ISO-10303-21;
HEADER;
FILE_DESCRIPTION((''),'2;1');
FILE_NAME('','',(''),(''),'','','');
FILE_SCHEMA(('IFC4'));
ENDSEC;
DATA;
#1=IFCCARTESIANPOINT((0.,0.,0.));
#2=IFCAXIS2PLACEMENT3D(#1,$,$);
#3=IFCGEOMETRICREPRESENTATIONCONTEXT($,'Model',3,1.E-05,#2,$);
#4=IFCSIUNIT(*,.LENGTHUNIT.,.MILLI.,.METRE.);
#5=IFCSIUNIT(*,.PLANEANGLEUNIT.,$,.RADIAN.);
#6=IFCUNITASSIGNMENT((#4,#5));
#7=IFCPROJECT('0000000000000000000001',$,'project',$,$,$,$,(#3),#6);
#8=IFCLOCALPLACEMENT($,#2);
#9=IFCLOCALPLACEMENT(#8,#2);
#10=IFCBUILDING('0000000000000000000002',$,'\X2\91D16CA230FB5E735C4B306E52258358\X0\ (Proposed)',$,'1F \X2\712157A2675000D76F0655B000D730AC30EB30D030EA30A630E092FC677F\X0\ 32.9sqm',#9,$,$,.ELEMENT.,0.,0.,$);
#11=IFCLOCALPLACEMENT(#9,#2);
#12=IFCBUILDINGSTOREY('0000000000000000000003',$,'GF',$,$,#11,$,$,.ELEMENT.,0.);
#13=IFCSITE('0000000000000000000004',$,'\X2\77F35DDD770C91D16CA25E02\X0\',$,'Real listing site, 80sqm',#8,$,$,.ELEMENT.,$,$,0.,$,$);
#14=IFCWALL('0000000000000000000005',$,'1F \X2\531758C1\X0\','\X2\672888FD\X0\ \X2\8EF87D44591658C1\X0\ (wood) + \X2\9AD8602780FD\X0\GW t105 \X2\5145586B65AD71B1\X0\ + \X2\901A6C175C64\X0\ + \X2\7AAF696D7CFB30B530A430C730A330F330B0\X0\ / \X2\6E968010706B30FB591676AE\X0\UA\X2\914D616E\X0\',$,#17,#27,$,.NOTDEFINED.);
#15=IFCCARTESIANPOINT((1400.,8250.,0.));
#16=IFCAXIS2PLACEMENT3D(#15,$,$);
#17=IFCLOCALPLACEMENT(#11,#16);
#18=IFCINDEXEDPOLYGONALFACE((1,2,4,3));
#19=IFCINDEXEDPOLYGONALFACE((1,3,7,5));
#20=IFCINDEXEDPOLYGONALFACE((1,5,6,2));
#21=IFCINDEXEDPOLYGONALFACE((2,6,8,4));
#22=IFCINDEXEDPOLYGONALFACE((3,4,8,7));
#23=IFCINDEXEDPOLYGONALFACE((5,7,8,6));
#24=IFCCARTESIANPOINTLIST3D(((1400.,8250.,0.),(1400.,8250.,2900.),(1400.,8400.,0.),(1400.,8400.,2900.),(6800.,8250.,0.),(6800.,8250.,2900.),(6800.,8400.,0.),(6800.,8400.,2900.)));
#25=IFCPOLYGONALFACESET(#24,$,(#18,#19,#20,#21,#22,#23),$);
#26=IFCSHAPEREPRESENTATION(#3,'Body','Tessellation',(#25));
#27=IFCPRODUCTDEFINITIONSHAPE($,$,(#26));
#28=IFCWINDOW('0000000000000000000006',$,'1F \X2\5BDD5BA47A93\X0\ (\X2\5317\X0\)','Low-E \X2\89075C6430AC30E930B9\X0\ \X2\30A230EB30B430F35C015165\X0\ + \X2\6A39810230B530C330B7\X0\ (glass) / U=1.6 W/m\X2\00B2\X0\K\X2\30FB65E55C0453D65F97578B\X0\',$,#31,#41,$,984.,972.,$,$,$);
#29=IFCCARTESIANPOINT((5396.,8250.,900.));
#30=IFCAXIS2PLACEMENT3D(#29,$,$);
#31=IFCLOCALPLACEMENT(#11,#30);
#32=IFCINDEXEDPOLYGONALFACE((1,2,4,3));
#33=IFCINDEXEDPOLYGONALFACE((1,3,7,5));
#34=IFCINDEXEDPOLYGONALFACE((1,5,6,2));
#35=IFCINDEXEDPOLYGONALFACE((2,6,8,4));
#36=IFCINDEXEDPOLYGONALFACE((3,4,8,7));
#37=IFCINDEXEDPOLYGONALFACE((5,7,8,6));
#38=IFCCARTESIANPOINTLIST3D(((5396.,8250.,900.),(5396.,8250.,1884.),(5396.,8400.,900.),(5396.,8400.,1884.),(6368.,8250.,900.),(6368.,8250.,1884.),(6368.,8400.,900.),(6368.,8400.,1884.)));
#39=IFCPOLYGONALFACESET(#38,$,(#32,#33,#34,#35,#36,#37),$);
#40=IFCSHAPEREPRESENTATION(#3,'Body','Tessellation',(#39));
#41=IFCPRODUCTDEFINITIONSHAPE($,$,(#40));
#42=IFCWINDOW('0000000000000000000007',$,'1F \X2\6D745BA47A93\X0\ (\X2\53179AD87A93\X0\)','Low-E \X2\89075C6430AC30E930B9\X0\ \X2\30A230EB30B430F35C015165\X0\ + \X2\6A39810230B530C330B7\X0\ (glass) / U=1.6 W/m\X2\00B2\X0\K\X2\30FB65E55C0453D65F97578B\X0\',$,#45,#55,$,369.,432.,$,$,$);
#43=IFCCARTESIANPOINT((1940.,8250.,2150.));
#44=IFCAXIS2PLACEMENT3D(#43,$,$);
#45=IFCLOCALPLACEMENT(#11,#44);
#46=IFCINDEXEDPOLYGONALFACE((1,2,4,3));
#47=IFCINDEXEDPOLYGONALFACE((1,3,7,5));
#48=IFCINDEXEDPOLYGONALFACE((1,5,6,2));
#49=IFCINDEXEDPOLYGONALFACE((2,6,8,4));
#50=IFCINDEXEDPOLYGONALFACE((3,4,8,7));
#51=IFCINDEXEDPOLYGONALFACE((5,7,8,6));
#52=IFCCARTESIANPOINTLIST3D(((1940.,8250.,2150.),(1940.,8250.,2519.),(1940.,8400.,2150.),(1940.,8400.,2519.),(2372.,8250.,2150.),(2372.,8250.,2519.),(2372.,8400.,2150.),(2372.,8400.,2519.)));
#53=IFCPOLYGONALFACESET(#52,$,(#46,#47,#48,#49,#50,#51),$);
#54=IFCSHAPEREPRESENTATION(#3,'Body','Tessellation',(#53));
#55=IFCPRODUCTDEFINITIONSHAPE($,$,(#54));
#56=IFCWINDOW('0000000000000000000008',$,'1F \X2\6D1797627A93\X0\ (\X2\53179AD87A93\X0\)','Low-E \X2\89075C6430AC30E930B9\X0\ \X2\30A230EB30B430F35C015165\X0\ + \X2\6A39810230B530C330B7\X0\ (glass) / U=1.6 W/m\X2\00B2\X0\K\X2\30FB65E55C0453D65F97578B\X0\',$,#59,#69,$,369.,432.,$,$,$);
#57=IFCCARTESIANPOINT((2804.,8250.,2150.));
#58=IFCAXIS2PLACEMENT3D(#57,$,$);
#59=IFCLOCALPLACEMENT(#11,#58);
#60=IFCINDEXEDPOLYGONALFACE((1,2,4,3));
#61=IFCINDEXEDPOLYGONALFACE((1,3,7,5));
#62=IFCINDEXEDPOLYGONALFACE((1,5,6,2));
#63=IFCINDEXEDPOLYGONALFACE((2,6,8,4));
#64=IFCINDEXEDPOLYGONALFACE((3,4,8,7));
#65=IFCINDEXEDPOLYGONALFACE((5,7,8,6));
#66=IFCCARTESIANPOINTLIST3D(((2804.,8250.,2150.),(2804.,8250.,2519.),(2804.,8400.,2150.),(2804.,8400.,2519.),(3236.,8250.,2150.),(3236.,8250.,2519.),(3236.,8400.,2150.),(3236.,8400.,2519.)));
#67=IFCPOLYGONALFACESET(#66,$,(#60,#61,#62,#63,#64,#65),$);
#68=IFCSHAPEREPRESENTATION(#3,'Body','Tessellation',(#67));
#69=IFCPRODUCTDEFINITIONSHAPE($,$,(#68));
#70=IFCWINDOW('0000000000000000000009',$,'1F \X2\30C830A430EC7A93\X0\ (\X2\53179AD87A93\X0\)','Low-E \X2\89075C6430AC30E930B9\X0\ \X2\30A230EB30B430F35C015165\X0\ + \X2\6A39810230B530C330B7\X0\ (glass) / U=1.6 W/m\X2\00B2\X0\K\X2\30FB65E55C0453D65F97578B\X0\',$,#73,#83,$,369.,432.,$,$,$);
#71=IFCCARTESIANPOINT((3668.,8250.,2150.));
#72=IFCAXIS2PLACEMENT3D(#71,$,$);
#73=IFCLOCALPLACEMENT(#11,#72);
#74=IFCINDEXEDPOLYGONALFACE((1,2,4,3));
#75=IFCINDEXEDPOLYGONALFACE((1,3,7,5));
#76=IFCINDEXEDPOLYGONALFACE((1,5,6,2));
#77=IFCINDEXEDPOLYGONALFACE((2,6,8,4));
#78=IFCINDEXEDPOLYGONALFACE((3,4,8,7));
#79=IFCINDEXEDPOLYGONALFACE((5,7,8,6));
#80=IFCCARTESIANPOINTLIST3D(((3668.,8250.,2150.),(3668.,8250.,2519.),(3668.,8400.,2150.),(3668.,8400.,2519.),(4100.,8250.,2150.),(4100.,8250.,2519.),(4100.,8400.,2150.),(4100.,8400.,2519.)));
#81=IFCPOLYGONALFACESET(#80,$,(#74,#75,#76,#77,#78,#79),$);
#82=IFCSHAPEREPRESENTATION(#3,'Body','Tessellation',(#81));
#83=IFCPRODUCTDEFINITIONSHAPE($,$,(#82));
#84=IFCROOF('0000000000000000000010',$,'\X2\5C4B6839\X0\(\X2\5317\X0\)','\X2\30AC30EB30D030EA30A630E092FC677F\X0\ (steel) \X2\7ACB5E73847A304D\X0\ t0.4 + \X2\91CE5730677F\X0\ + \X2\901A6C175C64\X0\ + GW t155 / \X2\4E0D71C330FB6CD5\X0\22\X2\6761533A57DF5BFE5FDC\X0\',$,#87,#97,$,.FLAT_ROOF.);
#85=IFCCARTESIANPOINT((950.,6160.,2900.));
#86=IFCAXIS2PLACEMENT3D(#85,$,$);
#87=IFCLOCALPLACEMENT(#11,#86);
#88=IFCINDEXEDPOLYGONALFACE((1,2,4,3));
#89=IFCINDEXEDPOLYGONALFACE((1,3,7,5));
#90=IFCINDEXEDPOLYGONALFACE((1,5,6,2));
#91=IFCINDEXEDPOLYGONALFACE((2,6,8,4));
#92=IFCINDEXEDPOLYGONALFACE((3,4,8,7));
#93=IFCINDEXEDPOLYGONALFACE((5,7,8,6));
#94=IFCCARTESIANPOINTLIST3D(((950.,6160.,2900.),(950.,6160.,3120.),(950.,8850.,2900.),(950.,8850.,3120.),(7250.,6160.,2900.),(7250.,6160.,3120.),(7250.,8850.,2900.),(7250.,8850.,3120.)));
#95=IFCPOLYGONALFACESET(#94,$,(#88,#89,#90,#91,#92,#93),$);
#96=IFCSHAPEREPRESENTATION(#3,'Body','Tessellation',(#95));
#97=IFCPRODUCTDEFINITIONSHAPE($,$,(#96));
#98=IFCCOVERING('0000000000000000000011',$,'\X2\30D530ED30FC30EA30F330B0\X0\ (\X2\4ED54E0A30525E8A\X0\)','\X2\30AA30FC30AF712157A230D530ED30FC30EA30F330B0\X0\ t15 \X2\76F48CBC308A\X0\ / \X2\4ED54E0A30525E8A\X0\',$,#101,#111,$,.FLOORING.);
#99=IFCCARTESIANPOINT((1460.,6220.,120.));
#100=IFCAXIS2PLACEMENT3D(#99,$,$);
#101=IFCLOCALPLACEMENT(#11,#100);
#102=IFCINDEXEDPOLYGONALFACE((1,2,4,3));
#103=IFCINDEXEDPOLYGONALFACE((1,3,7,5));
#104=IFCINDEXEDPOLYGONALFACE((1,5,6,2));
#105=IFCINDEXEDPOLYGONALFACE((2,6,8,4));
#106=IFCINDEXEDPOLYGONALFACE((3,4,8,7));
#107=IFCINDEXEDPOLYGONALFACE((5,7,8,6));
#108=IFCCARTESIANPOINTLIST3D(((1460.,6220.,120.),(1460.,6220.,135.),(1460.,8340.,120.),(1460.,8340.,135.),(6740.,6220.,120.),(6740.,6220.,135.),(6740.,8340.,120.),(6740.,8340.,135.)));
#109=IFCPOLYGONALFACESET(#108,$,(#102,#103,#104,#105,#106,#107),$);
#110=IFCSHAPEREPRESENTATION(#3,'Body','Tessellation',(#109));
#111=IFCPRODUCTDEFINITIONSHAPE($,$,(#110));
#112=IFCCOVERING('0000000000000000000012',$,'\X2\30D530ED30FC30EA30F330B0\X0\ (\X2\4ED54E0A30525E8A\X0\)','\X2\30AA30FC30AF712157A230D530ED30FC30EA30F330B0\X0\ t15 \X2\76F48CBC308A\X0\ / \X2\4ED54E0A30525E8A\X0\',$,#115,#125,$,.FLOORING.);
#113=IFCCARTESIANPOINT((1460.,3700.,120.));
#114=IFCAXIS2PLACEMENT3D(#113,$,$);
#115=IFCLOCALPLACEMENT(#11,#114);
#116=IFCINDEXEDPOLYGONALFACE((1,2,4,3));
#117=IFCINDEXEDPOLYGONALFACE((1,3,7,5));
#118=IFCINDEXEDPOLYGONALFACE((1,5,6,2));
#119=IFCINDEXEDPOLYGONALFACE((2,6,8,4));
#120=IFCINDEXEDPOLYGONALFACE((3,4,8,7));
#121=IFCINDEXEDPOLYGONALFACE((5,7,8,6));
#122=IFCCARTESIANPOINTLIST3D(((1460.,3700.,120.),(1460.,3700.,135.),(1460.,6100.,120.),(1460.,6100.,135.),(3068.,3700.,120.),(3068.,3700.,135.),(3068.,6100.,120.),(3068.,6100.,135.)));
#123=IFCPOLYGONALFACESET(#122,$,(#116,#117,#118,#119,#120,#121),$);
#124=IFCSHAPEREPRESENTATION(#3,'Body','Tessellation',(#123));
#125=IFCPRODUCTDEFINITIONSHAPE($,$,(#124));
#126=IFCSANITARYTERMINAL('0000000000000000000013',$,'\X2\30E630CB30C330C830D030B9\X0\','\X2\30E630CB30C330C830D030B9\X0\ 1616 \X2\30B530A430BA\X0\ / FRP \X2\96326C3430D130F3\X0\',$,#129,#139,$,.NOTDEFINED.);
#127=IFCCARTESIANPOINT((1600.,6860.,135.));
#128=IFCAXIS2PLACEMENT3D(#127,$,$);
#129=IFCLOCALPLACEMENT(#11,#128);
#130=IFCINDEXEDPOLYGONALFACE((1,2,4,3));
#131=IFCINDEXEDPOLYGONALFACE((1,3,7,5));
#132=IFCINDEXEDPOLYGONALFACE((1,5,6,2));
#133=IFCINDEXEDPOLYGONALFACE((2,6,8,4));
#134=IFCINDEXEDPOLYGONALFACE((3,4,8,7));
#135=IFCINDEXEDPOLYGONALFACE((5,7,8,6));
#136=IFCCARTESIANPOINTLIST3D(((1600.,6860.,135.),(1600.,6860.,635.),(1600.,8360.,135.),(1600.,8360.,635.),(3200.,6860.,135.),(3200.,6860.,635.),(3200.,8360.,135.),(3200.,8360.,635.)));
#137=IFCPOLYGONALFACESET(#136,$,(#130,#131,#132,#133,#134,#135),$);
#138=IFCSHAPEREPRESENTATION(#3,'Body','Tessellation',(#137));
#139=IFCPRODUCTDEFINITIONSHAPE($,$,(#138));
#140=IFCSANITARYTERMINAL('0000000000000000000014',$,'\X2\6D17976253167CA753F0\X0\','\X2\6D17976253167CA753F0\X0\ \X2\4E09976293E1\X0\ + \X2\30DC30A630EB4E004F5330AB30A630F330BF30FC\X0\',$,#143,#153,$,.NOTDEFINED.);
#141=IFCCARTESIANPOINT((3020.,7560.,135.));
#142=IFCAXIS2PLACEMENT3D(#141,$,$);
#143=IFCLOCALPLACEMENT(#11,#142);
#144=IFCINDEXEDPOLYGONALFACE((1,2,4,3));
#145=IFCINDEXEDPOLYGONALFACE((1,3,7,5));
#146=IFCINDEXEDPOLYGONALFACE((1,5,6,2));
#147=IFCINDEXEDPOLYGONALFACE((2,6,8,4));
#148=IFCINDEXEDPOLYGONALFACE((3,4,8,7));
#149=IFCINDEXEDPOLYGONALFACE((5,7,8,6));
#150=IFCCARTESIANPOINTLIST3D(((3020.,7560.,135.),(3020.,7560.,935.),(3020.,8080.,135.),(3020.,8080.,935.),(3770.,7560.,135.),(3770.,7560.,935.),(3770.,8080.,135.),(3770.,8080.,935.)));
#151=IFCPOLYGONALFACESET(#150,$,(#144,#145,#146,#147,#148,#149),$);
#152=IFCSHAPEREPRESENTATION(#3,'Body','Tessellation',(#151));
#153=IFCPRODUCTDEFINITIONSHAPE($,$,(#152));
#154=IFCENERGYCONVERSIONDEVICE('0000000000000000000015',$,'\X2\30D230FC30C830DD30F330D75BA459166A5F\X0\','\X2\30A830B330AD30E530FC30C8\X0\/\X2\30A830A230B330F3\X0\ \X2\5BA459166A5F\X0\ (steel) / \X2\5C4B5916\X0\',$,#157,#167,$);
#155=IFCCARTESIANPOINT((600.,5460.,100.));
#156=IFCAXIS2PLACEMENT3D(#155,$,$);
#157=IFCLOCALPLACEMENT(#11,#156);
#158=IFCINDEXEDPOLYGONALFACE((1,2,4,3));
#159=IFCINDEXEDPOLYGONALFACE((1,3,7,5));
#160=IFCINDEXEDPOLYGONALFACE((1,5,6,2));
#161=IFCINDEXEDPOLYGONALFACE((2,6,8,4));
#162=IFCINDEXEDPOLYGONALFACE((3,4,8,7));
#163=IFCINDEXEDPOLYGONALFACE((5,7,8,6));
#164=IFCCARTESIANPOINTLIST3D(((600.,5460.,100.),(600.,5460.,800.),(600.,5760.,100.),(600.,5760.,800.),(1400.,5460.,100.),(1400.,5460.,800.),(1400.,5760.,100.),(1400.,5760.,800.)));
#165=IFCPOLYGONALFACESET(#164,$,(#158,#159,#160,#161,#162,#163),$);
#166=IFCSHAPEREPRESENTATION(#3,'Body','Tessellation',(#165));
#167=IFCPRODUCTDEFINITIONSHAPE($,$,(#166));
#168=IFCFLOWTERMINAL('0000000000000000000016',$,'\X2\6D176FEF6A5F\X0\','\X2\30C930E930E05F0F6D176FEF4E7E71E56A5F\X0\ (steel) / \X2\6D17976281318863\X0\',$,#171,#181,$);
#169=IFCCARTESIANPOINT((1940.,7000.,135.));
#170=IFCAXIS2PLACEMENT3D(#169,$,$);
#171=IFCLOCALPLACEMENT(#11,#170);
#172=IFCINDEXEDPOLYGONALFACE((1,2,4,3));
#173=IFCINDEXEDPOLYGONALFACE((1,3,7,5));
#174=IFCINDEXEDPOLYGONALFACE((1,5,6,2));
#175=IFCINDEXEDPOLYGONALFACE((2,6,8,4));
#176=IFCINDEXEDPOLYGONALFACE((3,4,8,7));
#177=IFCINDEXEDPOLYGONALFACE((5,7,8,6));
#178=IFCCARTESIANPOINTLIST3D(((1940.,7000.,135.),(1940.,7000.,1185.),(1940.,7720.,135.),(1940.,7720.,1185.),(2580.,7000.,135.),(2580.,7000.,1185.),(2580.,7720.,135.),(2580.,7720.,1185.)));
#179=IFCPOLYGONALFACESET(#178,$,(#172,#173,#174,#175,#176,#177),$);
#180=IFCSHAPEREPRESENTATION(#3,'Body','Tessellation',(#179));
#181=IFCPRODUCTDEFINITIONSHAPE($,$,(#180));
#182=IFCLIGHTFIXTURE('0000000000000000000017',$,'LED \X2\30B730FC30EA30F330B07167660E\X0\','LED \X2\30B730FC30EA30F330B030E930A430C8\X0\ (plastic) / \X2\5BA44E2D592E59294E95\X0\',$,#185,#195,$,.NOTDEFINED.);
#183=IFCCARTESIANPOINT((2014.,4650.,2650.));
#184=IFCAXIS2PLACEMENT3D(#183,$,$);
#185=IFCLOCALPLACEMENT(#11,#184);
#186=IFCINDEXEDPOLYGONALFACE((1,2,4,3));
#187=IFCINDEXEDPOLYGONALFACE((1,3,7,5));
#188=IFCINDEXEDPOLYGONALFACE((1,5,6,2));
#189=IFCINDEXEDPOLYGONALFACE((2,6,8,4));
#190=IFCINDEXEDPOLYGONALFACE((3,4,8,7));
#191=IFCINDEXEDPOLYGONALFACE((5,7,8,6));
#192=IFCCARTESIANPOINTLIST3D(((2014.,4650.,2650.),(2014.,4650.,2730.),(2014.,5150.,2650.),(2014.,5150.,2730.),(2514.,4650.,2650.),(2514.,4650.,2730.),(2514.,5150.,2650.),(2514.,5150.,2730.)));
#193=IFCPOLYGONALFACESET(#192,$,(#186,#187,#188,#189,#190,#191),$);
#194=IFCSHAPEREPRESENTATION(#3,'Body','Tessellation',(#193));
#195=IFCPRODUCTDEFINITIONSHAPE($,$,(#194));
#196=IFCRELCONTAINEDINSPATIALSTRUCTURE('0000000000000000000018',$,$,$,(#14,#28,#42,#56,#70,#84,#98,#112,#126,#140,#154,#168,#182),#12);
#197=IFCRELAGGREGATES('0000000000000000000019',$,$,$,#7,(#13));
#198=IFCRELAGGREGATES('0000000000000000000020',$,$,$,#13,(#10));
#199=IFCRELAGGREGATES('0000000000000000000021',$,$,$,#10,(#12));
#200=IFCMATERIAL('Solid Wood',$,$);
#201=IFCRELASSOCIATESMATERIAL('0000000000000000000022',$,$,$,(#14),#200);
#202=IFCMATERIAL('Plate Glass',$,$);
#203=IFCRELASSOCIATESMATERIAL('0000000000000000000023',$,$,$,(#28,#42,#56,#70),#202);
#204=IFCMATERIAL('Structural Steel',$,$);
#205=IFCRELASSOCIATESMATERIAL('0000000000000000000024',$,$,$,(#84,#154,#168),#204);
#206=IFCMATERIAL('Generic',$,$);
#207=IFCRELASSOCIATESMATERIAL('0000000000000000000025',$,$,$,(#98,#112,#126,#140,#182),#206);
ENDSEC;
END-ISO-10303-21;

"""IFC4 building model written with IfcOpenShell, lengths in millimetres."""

from ifc_helpers import new_model, si_unit, frame, frame_2d, origin, place, context, project, spatial, rectangle, extrude, material, element, fill, save


model = new_model("IFC4")

# Units and contexts
model_context = context("Model", 3, precision=1e-05, world=origin())
ifc_project = project(units=[si_unit("LENGTHUNIT", "METRE", prefix="MILLI"), si_unit("PLANEANGLEUNIT", "RADIAN")], contexts=[model_context])

# Site, building, storey
site_placement = place(None, origin())
site = spatial("IfcSite", under=ifc_project, at=site_placement, Name="石川県金沢市", ObjectType="Real listing site, 80sqm", CompositionType="ELEMENT", RefElevation=0.0)
building_placement = place(site_placement, origin())
building = spatial("IfcBuilding", under=site, at=building_placement, Name="金沢・平屋の別荘 (Proposed)", ObjectType="1F 無垢材×漆喰×ガルバリウム鋼板 32.9sqm", CompositionType="ELEMENT", ElevationOfRefHeight=0.0, ElevationOfTerrain=0.0)
storey_placement = place(building_placement, origin())
storey = spatial("IfcBuildingStorey", under=building, at=storey_placement, Name="GF", CompositionType="ELEMENT", Elevation=0.0)

# Shared definitions
ifc_material_1 = material(Name="Solid Wood")

# Wall, openings, windows
wall_1_placement = place(storey_placement, frame((1400.0, 8250.0, 0.0)))
wall_1 = element("IfcWall", 1, at=wall_1_placement, inside=storey, material=ifc_material_1, Name="1F 北壁", Description="木製 軸組外壁 (wood) + 高性能GW t105 充填断熱 + 通気層 + 窯業系サイディング / 準耐火・外皮UA配慮", PredefinedType="NOTDEFINED", context=model_context, shape_type="SweptSolid", body=[
    extrude(rectangle(XDim=5400.0, YDim=150.0, at=frame_2d((2700.0, 75.0))), frame((1400.0, 8250.0, 0.0)), (0.0, 0.0, 1.0), 2900.0),
])
opening_1_placement = place(storey_placement, frame((5396.0, 8250.0, 900.0)))
opening_1 = element("IfcOpeningElement", 2, at=opening_1_placement, cuts=wall_1, PredefinedType="NOTDEFINED", context=model_context, shape_type="SweptSolid", body=[
    extrude(rectangle(XDim=972.0, YDim=150.0, at=frame_2d((486.0, 75.0))), frame((5396.0, 8250.0, 900.0)), (0.0, 0.0, 1.0), 984.0),
])
opening_2_placement = place(storey_placement, frame((1940.0, 8250.0, 2150.0)))
opening_2 = element("IfcOpeningElement", 3, at=opening_2_placement, cuts=wall_1, PredefinedType="NOTDEFINED", context=model_context, shape_type="SweptSolid", body=[
    extrude(rectangle(XDim=432.0, YDim=150.0, at=frame_2d((216.0, 75.0))), frame((1940.0, 8250.0, 2150.0)), (0.0, 0.0, 1.0), 369.0),
])
opening_3_placement = place(storey_placement, frame((2804.0, 8250.0, 2150.0)))
opening_3 = element("IfcOpeningElement", 4, at=opening_3_placement, cuts=wall_1, PredefinedType="NOTDEFINED", context=model_context, shape_type="SweptSolid", body=[
    extrude(rectangle(XDim=432.0, YDim=150.0, at=frame_2d((216.0, 75.0))), frame((2804.0, 8250.0, 2150.0)), (0.0, 0.0, 1.0), 369.0),
])
opening_4_placement = place(storey_placement, frame((3668.0, 8250.0, 2150.0)))
opening_4 = element("IfcOpeningElement", 5, at=opening_4_placement, cuts=wall_1, PredefinedType="NOTDEFINED", context=model_context, shape_type="SweptSolid", body=[
    extrude(rectangle(XDim=432.0, YDim=150.0, at=frame_2d((216.0, 75.0))), frame((3668.0, 8250.0, 2150.0)), (0.0, 0.0, 1.0), 369.0),
])
ifc_material_2 = material(Name="Plate Glass")
window_1_placement = place(storey_placement, frame((5396.0, 8250.0, 900.0)))
window_1 = element("IfcWindow", 6, at=window_1_placement, inside=storey, material=ifc_material_2, Name="1F 寝室窓 (北)", Description="Low-E 複層ガラス アルゴン封入 + 樹脂サッシ (glass) / U=1.6 W/m²K・日射取得型", OverallHeight=984.0, OverallWidth=972.0, context=model_context, shape_type="SweptSolid", body=[
    extrude(rectangle(XDim=972.0, YDim=150.0, at=frame_2d((486.0, 75.0))), frame((5396.0, 8250.0, 900.0)), (0.0, 0.0, 1.0), 984.0),
])
fill(opening_1, window_1)
window_2_placement = place(storey_placement, frame((1940.0, 8250.0, 2150.0)))
window_2 = element("IfcWindow", 7, at=window_2_placement, inside=storey, material=ifc_material_2, Name="1F 浴室窓 (北高窓)", Description="Low-E 複層ガラス アルゴン封入 + 樹脂サッシ (glass) / U=1.6 W/m²K・日射取得型", OverallHeight=369.0, OverallWidth=432.0, context=model_context, shape_type="SweptSolid", body=[
    extrude(rectangle(XDim=432.0, YDim=150.0, at=frame_2d((216.0, 75.0))), frame((1940.0, 8250.0, 2150.0)), (0.0, 0.0, 1.0), 369.0),
])
fill(opening_2, window_2)
window_3_placement = place(storey_placement, frame((2804.0, 8250.0, 2150.0)))
window_3 = element("IfcWindow", 8, at=window_3_placement, inside=storey, material=ifc_material_2, Name="1F 洗面窓 (北高窓)", Description="Low-E 複層ガラス アルゴン封入 + 樹脂サッシ (glass) / U=1.6 W/m²K・日射取得型", OverallHeight=369.0, OverallWidth=432.0, context=model_context, shape_type="SweptSolid", body=[
    extrude(rectangle(XDim=432.0, YDim=150.0, at=frame_2d((216.0, 75.0))), frame((2804.0, 8250.0, 2150.0)), (0.0, 0.0, 1.0), 369.0),
])
fill(opening_3, window_3)
window_4_placement = place(storey_placement, frame((3668.0, 8250.0, 2150.0)))
window_4 = element("IfcWindow", 9, at=window_4_placement, inside=storey, material=ifc_material_2, Name="1F トイレ窓 (北高窓)", Description="Low-E 複層ガラス アルゴン封入 + 樹脂サッシ (glass) / U=1.6 W/m²K・日射取得型", OverallHeight=369.0, OverallWidth=432.0, context=model_context, shape_type="SweptSolid", body=[
    extrude(rectangle(XDim=432.0, YDim=150.0, at=frame_2d((216.0, 75.0))), frame((3668.0, 8250.0, 2150.0)), (0.0, 0.0, 1.0), 369.0),
])
fill(opening_4, window_4)

# Roof
ifc_material_3 = material(Name="Structural Steel")
roof_placement = place(storey_placement, frame((950.0, 6160.0, 2900.0)))
element("IfcRoof", 10, at=roof_placement, inside=storey, material=ifc_material_3, Name="屋根(北)", Description="ガルバリウム鋼板 (steel) 立平葺き t0.4 + 野地板 + 通気層 + GW t155 / 不燃・法22条区域対応", PredefinedType="FLAT_ROOF", context=model_context, shape_type="SweptSolid", body=[
    extrude(rectangle(XDim=6300.0, YDim=2690.0, at=frame_2d((3150.0, 1345.0))), frame((950.0, 6160.0, 2900.0)), (0.0, 0.0, 1.0), 220.0),
])

# Coverings
ifc_material_4 = material(Name="Generic")
covering_1_placement = place(storey_placement, frame((1460.0, 6220.0, 120.0)))
element("IfcCovering", 11, at=covering_1_placement, inside=storey, material=ifc_material_4, Name="フローリング (仕上げ床)", Description="オーク無垢フローリング t15 直貼り / 仕上げ床", PredefinedType="FLOORING", context=model_context, shape_type="SweptSolid", body=[
    extrude(rectangle(XDim=5280.0, YDim=2120.0, at=frame_2d((2640.0, 1060.0))), frame((1460.0, 6220.0, 120.0)), (0.0, 0.0, 1.0), 15.0),
])
covering_2_placement = place(storey_placement, frame((1460.0, 3700.0, 120.0)))
element("IfcCovering", 12, at=covering_2_placement, inside=storey, material=ifc_material_4, Name="フローリング (仕上げ床)", Description="オーク無垢フローリング t15 直貼り / 仕上げ床", PredefinedType="FLOORING", context=model_context, shape_type="SweptSolid", body=[
    extrude(rectangle(XDim=1608.0, YDim=2400.0, at=frame_2d((804.0, 1200.0))), frame((1460.0, 3700.0, 120.0)), (0.0, 0.0, 1.0), 15.0),
])

# Sanitary terminals
sanitary_terminal_1_placement = place(storey_placement, frame((1600.0, 6860.0, 135.0)))
element("IfcSanitaryTerminal", 13, at=sanitary_terminal_1_placement, inside=storey, material=ifc_material_4, Name="ユニットバス", Description="ユニットバス 1616 サイズ / FRP 防水パン", PredefinedType="NOTDEFINED", context=model_context, shape_type="SweptSolid", body=[
    extrude(rectangle(XDim=1600.0, YDim=1500.0, at=frame_2d((800.0, 750.0))), frame((1600.0, 6860.0, 135.0)), (0.0, 0.0, 1.0), 500.0),
])
sanitary_terminal_2_placement = place(storey_placement, frame((3020.0, 7560.0, 135.0)))
element("IfcSanitaryTerminal", 14, at=sanitary_terminal_2_placement, inside=storey, material=ifc_material_4, Name="洗面化粧台", Description="洗面化粧台 三面鏡 + ボウル一体カウンター", PredefinedType="NOTDEFINED", context=model_context, shape_type="SweptSolid", body=[
    extrude(rectangle(XDim=750.0, YDim=520.0, at=frame_2d((375.0, 260.0))), frame((3020.0, 7560.0, 135.0)), (0.0, 0.0, 1.0), 800.0),
])

# Energy conversion device
energy_conversion_device_placement = place(storey_placement, frame((600.0, 5460.0, 100.0)))
element("IfcEnergyConversionDevice", 15, at=energy_conversion_device_placement, inside=storey, material=ifc_material_3, Name="ヒートポンプ室外機", Description="エコキュート/エアコン 室外機 (steel) / 屋外", context=model_context, shape_type="SweptSolid", body=[
    extrude(rectangle(XDim=800.0, YDim=300.0, at=frame_2d((400.0, 150.0))), frame((600.0, 5460.0, 100.0)), (0.0, 0.0, 1.0), 700.0),
])

# Flow terminal
flow_terminal_placement = place(storey_placement, frame((1940.0, 7000.0, 135.0)))
element("IfcFlowTerminal", 16, at=flow_terminal_placement, inside=storey, material=ifc_material_3, Name="洗濯機", Description="ドラム式洗濯乾燥機 (steel) / 洗面脱衣", context=model_context, shape_type="SweptSolid", body=[
    extrude(rectangle(XDim=640.0, YDim=720.0, at=frame_2d((320.0, 360.0))), frame((1940.0, 7000.0, 135.0)), (0.0, 0.0, 1.0), 1050.0),
])

# Light fixture
light_fixture_placement = place(storey_placement, frame((2014.0, 4650.0, 2650.0)))
element("IfcLightFixture", 17, at=light_fixture_placement, inside=storey, material=ifc_material_4, Name="LED シーリング照明", Description="LED シーリングライト (plastic) / 室中央天井", PredefinedType="NOTDEFINED", context=model_context, shape_type="SweptSolid", body=[
    extrude(rectangle(XDim=500.0, YDim=500.0, at=frame_2d((250.0, 250.0))), frame((2014.0, 4650.0, 2650.0)), (0.0, 0.0, 1.0), 80.0),
])

save(model, "model.ifc")
